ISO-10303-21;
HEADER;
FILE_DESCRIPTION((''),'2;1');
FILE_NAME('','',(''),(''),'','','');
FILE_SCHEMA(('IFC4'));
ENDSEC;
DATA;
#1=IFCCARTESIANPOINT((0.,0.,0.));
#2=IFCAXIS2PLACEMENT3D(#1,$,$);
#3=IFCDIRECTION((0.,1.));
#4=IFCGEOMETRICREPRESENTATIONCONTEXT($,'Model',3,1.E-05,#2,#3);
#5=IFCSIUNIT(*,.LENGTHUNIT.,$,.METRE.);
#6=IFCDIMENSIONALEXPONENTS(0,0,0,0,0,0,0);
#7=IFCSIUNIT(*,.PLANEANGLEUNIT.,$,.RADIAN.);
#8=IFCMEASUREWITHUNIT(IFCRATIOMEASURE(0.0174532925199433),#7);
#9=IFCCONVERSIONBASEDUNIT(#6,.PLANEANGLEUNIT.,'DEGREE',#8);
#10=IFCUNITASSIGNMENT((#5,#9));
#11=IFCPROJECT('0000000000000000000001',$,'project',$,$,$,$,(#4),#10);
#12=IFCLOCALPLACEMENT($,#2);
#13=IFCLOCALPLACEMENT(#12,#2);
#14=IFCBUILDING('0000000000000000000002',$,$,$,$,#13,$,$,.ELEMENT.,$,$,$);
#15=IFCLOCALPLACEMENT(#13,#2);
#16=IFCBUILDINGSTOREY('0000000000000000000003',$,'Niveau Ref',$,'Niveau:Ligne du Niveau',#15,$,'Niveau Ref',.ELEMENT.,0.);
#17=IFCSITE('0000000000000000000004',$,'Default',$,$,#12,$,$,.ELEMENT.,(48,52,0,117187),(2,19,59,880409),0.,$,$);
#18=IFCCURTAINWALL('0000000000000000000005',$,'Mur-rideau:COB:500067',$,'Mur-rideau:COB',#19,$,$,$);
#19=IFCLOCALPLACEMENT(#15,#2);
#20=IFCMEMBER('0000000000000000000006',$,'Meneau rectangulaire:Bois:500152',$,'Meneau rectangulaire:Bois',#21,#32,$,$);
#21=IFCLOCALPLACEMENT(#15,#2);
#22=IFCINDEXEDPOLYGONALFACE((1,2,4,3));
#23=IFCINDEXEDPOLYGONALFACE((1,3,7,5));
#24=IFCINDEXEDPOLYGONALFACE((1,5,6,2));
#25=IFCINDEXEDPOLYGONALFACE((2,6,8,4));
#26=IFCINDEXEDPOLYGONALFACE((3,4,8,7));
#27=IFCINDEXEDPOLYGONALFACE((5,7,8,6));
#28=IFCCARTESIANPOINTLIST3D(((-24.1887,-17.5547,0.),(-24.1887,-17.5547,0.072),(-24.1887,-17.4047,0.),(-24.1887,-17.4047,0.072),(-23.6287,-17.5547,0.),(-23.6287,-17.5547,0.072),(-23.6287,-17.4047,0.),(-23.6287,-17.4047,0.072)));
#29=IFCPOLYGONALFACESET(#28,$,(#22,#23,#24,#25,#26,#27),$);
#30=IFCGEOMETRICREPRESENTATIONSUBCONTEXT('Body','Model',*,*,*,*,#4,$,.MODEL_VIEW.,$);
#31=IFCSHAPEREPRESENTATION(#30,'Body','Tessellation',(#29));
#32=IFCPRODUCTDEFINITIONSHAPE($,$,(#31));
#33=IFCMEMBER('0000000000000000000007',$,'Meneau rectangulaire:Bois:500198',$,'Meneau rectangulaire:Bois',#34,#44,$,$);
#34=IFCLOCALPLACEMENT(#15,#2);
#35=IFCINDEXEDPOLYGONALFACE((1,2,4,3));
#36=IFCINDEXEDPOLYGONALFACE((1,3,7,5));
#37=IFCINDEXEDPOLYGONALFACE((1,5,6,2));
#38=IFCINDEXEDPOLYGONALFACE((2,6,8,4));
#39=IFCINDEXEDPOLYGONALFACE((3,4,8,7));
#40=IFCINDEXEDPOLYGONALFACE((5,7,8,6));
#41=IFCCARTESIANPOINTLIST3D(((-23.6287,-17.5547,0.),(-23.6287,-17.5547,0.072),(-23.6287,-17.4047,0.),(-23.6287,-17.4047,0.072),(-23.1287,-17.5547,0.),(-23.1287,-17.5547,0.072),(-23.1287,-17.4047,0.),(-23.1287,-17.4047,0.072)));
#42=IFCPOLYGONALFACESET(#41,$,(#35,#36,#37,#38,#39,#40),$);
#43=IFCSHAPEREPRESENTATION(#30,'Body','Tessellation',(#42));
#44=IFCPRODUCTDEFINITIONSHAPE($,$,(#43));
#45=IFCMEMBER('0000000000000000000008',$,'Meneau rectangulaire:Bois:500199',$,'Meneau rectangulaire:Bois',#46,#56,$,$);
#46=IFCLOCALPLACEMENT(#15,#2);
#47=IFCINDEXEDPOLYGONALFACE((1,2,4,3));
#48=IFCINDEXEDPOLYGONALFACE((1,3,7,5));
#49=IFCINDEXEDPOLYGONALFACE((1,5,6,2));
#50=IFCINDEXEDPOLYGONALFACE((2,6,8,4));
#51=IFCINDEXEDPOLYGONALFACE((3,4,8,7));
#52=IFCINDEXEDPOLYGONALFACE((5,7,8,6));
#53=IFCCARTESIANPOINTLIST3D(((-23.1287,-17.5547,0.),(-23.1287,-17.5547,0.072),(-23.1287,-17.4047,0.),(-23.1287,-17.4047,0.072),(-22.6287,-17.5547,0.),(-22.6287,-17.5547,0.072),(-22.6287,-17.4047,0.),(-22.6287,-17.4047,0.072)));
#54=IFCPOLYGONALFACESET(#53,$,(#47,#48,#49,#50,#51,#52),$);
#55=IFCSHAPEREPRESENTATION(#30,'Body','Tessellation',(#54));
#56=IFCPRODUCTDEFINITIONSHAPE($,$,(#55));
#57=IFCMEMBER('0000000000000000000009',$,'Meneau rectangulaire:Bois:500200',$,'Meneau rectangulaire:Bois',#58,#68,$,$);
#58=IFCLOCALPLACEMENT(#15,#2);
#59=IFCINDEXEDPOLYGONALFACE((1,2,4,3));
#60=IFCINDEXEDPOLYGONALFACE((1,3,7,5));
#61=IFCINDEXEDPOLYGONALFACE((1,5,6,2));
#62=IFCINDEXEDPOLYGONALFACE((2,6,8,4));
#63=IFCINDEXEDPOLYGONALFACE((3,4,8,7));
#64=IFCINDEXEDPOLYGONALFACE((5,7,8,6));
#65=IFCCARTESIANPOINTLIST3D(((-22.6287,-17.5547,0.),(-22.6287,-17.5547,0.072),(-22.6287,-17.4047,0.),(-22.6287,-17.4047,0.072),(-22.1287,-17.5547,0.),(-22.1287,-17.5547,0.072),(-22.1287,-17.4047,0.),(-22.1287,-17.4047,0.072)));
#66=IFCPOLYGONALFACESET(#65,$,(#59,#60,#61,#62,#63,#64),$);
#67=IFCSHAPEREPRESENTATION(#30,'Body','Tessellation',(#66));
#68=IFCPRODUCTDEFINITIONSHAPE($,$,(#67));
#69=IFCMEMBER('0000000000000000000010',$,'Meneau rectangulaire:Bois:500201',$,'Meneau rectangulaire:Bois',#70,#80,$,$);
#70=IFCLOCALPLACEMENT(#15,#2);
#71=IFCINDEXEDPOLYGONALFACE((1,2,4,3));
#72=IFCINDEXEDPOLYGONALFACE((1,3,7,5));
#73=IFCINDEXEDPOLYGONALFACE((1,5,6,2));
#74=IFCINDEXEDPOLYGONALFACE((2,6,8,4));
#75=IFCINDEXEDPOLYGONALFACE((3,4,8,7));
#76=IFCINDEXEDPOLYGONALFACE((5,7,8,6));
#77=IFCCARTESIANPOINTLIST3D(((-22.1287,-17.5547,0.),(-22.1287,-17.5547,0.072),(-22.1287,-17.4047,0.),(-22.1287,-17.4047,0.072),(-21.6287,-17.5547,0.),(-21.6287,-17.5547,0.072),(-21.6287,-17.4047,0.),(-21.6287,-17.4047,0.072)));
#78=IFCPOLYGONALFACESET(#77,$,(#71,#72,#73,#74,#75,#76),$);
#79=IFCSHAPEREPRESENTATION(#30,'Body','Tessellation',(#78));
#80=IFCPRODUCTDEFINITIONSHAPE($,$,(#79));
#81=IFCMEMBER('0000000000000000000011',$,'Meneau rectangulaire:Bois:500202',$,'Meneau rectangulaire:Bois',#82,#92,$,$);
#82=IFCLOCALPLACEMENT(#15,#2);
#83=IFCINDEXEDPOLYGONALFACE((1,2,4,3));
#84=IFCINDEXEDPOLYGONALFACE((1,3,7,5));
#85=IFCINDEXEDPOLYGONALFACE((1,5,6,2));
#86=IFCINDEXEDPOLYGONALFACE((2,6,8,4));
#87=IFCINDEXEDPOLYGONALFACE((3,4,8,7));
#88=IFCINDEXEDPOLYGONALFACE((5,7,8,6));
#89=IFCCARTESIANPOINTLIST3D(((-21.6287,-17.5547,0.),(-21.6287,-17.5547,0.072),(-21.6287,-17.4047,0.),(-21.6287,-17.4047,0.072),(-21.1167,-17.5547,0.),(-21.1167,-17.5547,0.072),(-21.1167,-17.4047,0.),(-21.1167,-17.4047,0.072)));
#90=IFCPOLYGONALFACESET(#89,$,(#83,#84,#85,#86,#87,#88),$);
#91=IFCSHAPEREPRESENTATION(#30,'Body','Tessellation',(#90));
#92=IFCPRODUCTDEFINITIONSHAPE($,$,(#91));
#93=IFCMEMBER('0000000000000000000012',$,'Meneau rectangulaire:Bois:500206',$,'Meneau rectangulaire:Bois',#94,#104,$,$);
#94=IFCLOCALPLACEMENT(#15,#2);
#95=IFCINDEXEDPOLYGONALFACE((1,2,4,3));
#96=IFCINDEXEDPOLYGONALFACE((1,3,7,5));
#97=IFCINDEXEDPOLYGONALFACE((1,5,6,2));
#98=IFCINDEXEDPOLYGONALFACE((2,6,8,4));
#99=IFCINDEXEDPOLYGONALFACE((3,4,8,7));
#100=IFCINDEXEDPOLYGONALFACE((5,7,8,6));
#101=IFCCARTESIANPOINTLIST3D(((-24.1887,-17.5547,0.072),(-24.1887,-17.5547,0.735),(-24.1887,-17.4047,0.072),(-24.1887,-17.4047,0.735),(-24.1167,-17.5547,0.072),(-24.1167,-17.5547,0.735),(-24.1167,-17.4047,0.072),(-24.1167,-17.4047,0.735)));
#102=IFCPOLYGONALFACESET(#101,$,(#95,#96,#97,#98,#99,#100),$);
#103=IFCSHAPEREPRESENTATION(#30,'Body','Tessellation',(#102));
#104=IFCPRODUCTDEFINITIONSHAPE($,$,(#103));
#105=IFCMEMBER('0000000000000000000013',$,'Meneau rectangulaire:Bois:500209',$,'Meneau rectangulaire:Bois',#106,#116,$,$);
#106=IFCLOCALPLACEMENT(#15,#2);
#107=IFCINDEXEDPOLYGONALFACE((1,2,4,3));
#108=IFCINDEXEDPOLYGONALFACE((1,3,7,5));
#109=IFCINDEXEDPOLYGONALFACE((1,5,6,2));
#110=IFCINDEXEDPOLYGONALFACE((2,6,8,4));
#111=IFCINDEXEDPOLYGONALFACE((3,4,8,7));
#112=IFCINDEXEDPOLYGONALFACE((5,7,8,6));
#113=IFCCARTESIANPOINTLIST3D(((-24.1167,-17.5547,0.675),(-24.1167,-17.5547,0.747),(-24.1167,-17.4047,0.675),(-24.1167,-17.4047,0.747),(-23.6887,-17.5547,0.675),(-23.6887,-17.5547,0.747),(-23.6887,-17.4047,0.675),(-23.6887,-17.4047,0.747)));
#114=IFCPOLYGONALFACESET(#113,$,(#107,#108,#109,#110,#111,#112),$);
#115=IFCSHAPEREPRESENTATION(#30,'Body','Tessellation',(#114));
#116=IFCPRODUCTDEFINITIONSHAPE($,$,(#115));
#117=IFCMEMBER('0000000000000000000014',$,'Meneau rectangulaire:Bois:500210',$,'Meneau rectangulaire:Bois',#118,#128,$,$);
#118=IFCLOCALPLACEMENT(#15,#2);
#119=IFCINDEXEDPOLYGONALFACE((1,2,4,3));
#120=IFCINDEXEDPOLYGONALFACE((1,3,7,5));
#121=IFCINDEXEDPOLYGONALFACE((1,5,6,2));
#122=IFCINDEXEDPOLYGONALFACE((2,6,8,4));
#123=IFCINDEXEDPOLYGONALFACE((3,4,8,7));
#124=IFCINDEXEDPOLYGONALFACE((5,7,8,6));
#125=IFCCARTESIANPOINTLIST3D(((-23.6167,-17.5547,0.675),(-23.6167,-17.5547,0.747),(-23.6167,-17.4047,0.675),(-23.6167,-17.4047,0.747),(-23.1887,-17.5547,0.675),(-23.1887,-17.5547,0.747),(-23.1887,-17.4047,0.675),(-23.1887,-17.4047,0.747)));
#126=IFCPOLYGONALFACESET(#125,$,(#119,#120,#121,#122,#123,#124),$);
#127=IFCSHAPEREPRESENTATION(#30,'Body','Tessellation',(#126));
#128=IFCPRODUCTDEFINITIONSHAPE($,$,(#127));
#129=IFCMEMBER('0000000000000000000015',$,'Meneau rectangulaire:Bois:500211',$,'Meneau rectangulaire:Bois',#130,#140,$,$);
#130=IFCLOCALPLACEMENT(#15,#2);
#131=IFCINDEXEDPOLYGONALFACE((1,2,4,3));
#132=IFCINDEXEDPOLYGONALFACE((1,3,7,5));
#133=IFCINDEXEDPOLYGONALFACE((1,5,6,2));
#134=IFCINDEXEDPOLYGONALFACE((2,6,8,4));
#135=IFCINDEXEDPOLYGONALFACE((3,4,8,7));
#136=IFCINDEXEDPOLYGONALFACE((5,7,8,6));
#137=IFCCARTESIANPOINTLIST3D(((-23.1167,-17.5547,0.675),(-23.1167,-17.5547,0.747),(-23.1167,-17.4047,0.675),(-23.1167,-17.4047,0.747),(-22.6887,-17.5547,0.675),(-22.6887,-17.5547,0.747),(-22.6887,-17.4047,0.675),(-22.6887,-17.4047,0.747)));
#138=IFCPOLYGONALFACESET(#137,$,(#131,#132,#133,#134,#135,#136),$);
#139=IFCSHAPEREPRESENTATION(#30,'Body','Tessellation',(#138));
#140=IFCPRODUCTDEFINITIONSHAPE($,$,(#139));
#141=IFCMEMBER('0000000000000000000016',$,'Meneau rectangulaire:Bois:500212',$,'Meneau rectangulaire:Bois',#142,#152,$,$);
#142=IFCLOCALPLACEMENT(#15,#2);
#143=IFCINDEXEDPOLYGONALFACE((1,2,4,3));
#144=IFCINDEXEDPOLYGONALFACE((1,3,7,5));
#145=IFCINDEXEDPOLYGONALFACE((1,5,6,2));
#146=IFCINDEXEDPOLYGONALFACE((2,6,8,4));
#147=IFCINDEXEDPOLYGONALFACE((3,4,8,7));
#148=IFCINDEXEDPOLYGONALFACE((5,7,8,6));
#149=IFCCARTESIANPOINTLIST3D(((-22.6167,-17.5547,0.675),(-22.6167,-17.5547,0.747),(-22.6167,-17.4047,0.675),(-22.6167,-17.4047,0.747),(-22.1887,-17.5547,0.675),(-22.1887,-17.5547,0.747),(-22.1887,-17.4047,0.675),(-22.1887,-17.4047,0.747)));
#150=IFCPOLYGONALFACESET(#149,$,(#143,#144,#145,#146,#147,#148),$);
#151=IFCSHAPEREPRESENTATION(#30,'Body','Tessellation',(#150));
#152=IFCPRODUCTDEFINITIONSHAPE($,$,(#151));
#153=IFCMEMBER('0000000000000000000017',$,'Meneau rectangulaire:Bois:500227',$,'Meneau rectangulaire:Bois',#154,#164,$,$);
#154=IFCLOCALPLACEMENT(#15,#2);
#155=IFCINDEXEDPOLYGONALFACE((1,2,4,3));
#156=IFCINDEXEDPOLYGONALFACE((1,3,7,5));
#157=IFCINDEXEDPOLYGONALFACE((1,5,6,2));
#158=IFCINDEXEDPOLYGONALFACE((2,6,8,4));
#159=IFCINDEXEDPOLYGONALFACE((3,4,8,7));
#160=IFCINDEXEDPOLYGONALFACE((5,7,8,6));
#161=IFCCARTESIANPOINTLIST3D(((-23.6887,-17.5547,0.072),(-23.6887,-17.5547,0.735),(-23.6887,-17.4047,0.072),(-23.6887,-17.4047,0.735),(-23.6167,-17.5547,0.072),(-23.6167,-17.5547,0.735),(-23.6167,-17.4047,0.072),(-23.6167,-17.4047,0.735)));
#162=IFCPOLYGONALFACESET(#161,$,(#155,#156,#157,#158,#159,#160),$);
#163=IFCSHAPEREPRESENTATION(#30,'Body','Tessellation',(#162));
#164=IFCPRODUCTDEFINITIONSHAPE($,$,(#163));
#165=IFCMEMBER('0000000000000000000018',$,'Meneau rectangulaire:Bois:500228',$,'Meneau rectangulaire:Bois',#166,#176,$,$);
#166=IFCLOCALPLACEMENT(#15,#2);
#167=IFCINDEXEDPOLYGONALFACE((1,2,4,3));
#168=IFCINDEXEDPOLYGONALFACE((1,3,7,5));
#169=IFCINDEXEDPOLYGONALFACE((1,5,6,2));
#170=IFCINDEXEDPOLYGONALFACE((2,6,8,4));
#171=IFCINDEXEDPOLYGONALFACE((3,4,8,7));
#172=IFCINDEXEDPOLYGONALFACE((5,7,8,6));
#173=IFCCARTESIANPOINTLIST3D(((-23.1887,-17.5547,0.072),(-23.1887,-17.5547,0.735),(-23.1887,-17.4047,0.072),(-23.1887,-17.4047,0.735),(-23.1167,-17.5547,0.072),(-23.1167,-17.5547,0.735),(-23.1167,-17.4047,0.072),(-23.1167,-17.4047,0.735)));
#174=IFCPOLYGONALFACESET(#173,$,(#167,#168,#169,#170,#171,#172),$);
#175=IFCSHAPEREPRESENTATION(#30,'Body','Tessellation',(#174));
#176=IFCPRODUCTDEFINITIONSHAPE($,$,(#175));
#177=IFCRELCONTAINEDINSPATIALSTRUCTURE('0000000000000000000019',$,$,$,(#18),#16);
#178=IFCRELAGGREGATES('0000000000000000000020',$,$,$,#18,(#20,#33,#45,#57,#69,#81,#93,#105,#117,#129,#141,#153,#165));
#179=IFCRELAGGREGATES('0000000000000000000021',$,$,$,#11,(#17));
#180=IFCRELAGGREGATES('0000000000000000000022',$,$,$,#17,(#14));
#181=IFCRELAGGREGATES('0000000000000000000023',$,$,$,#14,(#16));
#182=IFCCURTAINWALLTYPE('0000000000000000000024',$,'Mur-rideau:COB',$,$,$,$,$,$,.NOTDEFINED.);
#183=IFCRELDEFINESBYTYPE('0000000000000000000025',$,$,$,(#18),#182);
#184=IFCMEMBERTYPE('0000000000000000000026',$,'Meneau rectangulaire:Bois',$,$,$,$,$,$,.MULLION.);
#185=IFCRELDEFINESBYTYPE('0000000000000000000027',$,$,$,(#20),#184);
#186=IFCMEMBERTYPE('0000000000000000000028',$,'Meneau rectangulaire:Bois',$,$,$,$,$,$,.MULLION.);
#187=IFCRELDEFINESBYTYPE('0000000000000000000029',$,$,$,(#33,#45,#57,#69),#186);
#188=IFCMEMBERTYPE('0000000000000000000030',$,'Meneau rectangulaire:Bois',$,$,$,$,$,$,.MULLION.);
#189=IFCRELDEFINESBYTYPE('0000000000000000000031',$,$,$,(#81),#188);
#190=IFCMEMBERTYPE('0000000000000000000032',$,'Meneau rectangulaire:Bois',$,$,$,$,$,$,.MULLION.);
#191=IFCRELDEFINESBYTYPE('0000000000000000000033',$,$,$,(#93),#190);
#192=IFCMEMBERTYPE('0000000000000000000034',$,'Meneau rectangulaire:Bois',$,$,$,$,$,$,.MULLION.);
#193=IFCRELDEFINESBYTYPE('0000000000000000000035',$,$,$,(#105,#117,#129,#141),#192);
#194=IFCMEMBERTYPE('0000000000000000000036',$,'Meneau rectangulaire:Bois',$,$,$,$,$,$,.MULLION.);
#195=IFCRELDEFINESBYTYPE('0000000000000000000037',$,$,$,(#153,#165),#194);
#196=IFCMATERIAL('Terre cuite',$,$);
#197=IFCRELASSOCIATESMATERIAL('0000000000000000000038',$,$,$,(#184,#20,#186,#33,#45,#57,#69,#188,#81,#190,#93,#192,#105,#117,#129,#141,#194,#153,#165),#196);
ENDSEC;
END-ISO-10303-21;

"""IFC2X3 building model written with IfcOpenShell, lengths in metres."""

from ifc_helpers import new_model, entity, si_unit, converted_unit, direction, frame, origin, origin_2d_with_axis, place, context, subcontext, project, spatial, rectangle, extrude, source, transform, mapped, material, type_object, type_shapes, element, aggregate, save


model = new_model("IFC2X3")

# Units and contexts
model_context = context("Model", 3, precision=1e-05, world=origin(), true_north=direction((0.0, 1.0)))
body_context = subcontext(model_context, "Body", "Model", "MODEL_VIEW")
ifc_project = project(units=[si_unit("LENGTHUNIT", "METRE"), converted_unit("PLANEANGLEUNIT", "DEGREE", entity("IfcRatioMeasure", 0.0174532925199433), si_unit("PLANEANGLEUNIT", "RADIAN"), dimensions=[0, 0, 0, 0, 0, 0, 0])], contexts=[model_context])

# Site, building, storey
site_placement = place(None, origin())
site = spatial("IfcSite", under=ifc_project, at=site_placement, Name="Default", CompositionType="ELEMENT", RefLatitude=(48, 52, 0, 117187), RefLongitude=(2, 19, 59, 880409), RefElevation=0.0)
building_placement = place(site_placement, origin())
building = spatial("IfcBuilding", under=site, at=building_placement, CompositionType="ELEMENT")
storey_placement = place(building_placement, origin())
storey = spatial("IfcBuildingStorey", under=building, at=storey_placement, Name="Niveau Ref", ObjectType="Niveau:Ligne du Niveau", LongName="Niveau Ref", CompositionType="ELEMENT", Elevation=0.0)

# Curtain wall, members
curtain_wall_type_1 = type_object("IfcCurtainWallType", Name="Mur-rideau:COB", PredefinedType="NOTDEFINED")
curtain_wall_1_placement = place(storey_placement, origin())
curtain_wall_1 = element("IfcCurtainWall", 1, at=curtain_wall_1_placement, inside=storey, type_object=curtain_wall_type_1, Name="Mur-rideau:COB:500067", ObjectType="Mur-rideau:COB")
ifc_material_1 = material(Name="Terre cuite")
member_type_1 = type_object("IfcMemberType", Name="Meneau rectangulaire:Bois", PredefinedType="MULLION", material=ifc_material_1)
shared_shape_1 = source(origin(), body_context, "Body", "SweptSolid", [
    extrude(rectangle(XDim=0.15, YDim=0.072, at=origin_2d_with_axis()), frame((-0.036, 0.0, -0.56), z_axis=(0.0, 0.0, 1.0), x_axis=(0.0, -1.0, 0.0)), (0.0, 0.0, 1.0), 0.56),
])
type_shapes(member_type_1, [shared_shape_1])
member_1_placement = place(storey_placement, frame((-24.1887, -17.4797, 0.0), z_axis=(-1.0, 0.0, 0.0), x_axis=(0.0, 0.0, -1.0)))
member_1 = element("IfcMember", 2, at=member_1_placement, type_object=member_type_1, material=ifc_material_1, Name="Meneau rectangulaire:Bois:500152", ObjectType="Meneau rectangulaire:Bois", context=body_context, shape_type="MappedRepresentation", body=[
    mapped(shared_shape_1, transform((0.0, 0.0, 0.0), scale=1.0)),
])
member_type_2 = type_object("IfcMemberType", Name="Meneau rectangulaire:Bois", PredefinedType="MULLION", material=ifc_material_1)
shared_shape_2 = source(origin(), body_context, "Body", "SweptSolid", [
    extrude(rectangle(XDim=0.15, YDim=0.072, at=origin_2d_with_axis()), frame((-0.036, 0.0, -0.5), z_axis=(0.0, 0.0, 1.0), x_axis=(0.0, -1.0, 0.0)), (0.0, 0.0, 1.0), 0.5),
])
type_shapes(member_type_2, [shared_shape_2])
member_2_placement = place(storey_placement, frame((-23.6287, -17.4797, 0.0), z_axis=(-1.0, 0.0, 0.0), x_axis=(0.0, 0.0, -1.0)))
member_2 = element("IfcMember", 3, at=member_2_placement, type_object=member_type_2, material=ifc_material_1, Name="Meneau rectangulaire:Bois:500198", ObjectType="Meneau rectangulaire:Bois", context=body_context, shape_type="MappedRepresentation", body=[
    mapped(shared_shape_2, transform((0.0, 0.0, 0.0), scale=1.0)),
])
member_3_placement = place(storey_placement, frame((-23.1287, -17.4797, 0.0), z_axis=(-1.0, 0.0, 0.0), x_axis=(0.0, 0.0, -1.0)))
member_3 = element("IfcMember", 4, at=member_3_placement, type_object=member_type_2, material=ifc_material_1, Name="Meneau rectangulaire:Bois:500199", ObjectType="Meneau rectangulaire:Bois", context=body_context, shape_type="MappedRepresentation", body=[
    mapped(shared_shape_2, transform((0.0, 0.0, 0.0), scale=1.0)),
])
member_4_placement = place(storey_placement, frame((-22.6287, -17.4797, 0.0), z_axis=(-1.0, 0.0, 0.0), x_axis=(0.0, 0.0, -1.0)))
member_4 = element("IfcMember", 5, at=member_4_placement, type_object=member_type_2, material=ifc_material_1, Name="Meneau rectangulaire:Bois:500200", ObjectType="Meneau rectangulaire:Bois", context=body_context, shape_type="MappedRepresentation", body=[
    mapped(shared_shape_2, transform((0.0, 0.0, 0.0), scale=1.0)),
])
member_5_placement = place(storey_placement, frame((-22.1287, -17.4797, 0.0), z_axis=(-1.0, 0.0, 0.0), x_axis=(0.0, 0.0, -1.0)))
member_5 = element("IfcMember", 6, at=member_5_placement, type_object=member_type_2, material=ifc_material_1, Name="Meneau rectangulaire:Bois:500201", ObjectType="Meneau rectangulaire:Bois", context=body_context, shape_type="MappedRepresentation", body=[
    mapped(shared_shape_2, transform((0.0, 0.0, 0.0), scale=1.0)),
])
member_type_3 = type_object("IfcMemberType", Name="Meneau rectangulaire:Bois", PredefinedType="MULLION", material=ifc_material_1)
shared_shape_3 = source(origin(), body_context, "Body", "SweptSolid", [
    extrude(rectangle(XDim=0.15, YDim=0.072, at=origin_2d_with_axis()), frame((-0.036, 0.0, -0.512), z_axis=(0.0, 0.0, 1.0), x_axis=(0.0, -1.0, 0.0)), (0.0, 0.0, 1.0), 0.512),
])
type_shapes(member_type_3, [shared_shape_3])
member_6_placement = place(storey_placement, frame((-21.6287, -17.4797, 0.0), z_axis=(-1.0, 0.0, 0.0), x_axis=(0.0, 0.0, -1.0)))
member_6 = element("IfcMember", 7, at=member_6_placement, type_object=member_type_3, material=ifc_material_1, Name="Meneau rectangulaire:Bois:500202", ObjectType="Meneau rectangulaire:Bois", context=body_context, shape_type="MappedRepresentation", body=[
    mapped(shared_shape_3, transform((0.0, 0.0, 0.0), scale=1.0)),
])
member_type_4 = type_object("IfcMemberType", Name="Meneau rectangulaire:Bois", PredefinedType="MULLION", material=ifc_material_1)
shared_shape_4 = source(origin(), body_context, "Body", "SweptSolid", [
    extrude(rectangle(XDim=0.15, YDim=0.072, at=origin_2d_with_axis()), frame((-0.036, 0.0, -0.663), z_axis=(0.0, 0.0, 1.0), x_axis=(0.0, -1.0, 0.0)), (0.0, 0.0, 1.0), 0.663),
])
type_shapes(member_type_4, [shared_shape_4])
member_7_placement = place(storey_placement, frame((-24.1887, -17.4797, 0.735), z_axis=(0.0, 0.0, 1.0), x_axis=(-1.0, 0.0, 0.0)))
member_7 = element("IfcMember", 8, at=member_7_placement, type_object=member_type_4, material=ifc_material_1, Name="Meneau rectangulaire:Bois:500206", ObjectType="Meneau rectangulaire:Bois", context=body_context, shape_type="MappedRepresentation", body=[
    mapped(shared_shape_4, transform((0.0, 0.0, 0.0), scale=1.0)),
])
member_type_5 = type_object("IfcMemberType", Name="Meneau rectangulaire:Bois", PredefinedType="MULLION", material=ifc_material_1)
shared_shape_5 = source(origin(), body_context, "Body", "SweptSolid", [
    extrude(rectangle(XDim=0.15, YDim=0.072, at=origin_2d_with_axis()), frame((-0.024, 0.0, -0.428), z_axis=(0.0, 0.0, 1.0), x_axis=(0.0, -1.0, 0.0)), (0.0, 0.0, 1.0), 0.428),
])
type_shapes(member_type_5, [shared_shape_5])
member_8_placement = place(storey_placement, frame((-23.6887, -17.4797, 0.735), z_axis=(1.0, 0.0, 0.0), x_axis=(0.0, 0.0, 1.0)))
member_8 = element("IfcMember", 9, at=member_8_placement, type_object=member_type_5, material=ifc_material_1, Name="Meneau rectangulaire:Bois:500209", ObjectType="Meneau rectangulaire:Bois", context=body_context, shape_type="MappedRepresentation", body=[
    mapped(shared_shape_5, transform((0.0, 0.0, 0.0), scale=1.0)),
])
member_9_placement = place(storey_placement, frame((-23.1887, -17.4797, 0.735), z_axis=(1.0, 0.0, 0.0), x_axis=(0.0, 0.0, 1.0)))
member_9 = element("IfcMember", 10, at=member_9_placement, type_object=member_type_5, material=ifc_material_1, Name="Meneau rectangulaire:Bois:500210", ObjectType="Meneau rectangulaire:Bois", context=body_context, shape_type="MappedRepresentation", body=[
    mapped(shared_shape_5, transform((0.0, 0.0, 0.0), scale=1.0)),
])
member_10_placement = place(storey_placement, frame((-22.6887, -17.4797, 0.735), z_axis=(1.0, 0.0, 0.0), x_axis=(0.0, 0.0, 1.0)))
member_10 = element("IfcMember", 11, at=member_10_placement, type_object=member_type_5, material=ifc_material_1, Name="Meneau rectangulaire:Bois:500211", ObjectType="Meneau rectangulaire:Bois", context=body_context, shape_type="MappedRepresentation", body=[
    mapped(shared_shape_5, transform((0.0, 0.0, 0.0), scale=1.0)),
])
member_11_placement = place(storey_placement, frame((-22.1887, -17.4797, 0.735), z_axis=(1.0, 0.0, 0.0), x_axis=(0.0, 0.0, 1.0)))
member_11 = element("IfcMember", 12, at=member_11_placement, type_object=member_type_5, material=ifc_material_1, Name="Meneau rectangulaire:Bois:500212", ObjectType="Meneau rectangulaire:Bois", context=body_context, shape_type="MappedRepresentation", body=[
    mapped(shared_shape_5, transform((0.0, 0.0, 0.0), scale=1.0)),
])
member_type_6 = type_object("IfcMemberType", Name="Meneau rectangulaire:Bois", PredefinedType="MULLION", material=ifc_material_1)
shared_shape_6 = source(origin(), body_context, "Body", "SweptSolid", [
    extrude(rectangle(XDim=0.15, YDim=0.072, at=origin_2d_with_axis()), frame((-0.024, 0.0, -0.663), z_axis=(0.0, 0.0, 1.0), x_axis=(0.0, -1.0, 0.0)), (0.0, 0.0, 1.0), 0.663),
])
type_shapes(member_type_6, [shared_shape_6])
member_12_placement = place(storey_placement, frame((-23.6287, -17.4797, 0.072), z_axis=(0.0, 0.0, -1.0), x_axis=(1.0, 0.0, 0.0)))
member_12 = element("IfcMember", 13, at=member_12_placement, type_object=member_type_6, material=ifc_material_1, Name="Meneau rectangulaire:Bois:500227", ObjectType="Meneau rectangulaire:Bois", context=body_context, shape_type="MappedRepresentation", body=[
    mapped(shared_shape_6, transform((0.0, 0.0, 0.0), scale=1.0)),
])
member_13_placement = place(storey_placement, frame((-23.1287, -17.4797, 0.072), z_axis=(0.0, 0.0, -1.0), x_axis=(1.0, 0.0, 0.0)))
member_13 = element("IfcMember", 14, at=member_13_placement, type_object=member_type_6, material=ifc_material_1, Name="Meneau rectangulaire:Bois:500228", ObjectType="Meneau rectangulaire:Bois", context=body_context, shape_type="MappedRepresentation", body=[
    mapped(shared_shape_6, transform((0.0, 0.0, 0.0), scale=1.0)),
])
aggregate(curtain_wall_1, [member_1, member_2, member_3, member_4, member_5, member_6, member_7, member_8, member_9, member_10, member_11, member_12, member_13])

save(model, "model.ifc")
